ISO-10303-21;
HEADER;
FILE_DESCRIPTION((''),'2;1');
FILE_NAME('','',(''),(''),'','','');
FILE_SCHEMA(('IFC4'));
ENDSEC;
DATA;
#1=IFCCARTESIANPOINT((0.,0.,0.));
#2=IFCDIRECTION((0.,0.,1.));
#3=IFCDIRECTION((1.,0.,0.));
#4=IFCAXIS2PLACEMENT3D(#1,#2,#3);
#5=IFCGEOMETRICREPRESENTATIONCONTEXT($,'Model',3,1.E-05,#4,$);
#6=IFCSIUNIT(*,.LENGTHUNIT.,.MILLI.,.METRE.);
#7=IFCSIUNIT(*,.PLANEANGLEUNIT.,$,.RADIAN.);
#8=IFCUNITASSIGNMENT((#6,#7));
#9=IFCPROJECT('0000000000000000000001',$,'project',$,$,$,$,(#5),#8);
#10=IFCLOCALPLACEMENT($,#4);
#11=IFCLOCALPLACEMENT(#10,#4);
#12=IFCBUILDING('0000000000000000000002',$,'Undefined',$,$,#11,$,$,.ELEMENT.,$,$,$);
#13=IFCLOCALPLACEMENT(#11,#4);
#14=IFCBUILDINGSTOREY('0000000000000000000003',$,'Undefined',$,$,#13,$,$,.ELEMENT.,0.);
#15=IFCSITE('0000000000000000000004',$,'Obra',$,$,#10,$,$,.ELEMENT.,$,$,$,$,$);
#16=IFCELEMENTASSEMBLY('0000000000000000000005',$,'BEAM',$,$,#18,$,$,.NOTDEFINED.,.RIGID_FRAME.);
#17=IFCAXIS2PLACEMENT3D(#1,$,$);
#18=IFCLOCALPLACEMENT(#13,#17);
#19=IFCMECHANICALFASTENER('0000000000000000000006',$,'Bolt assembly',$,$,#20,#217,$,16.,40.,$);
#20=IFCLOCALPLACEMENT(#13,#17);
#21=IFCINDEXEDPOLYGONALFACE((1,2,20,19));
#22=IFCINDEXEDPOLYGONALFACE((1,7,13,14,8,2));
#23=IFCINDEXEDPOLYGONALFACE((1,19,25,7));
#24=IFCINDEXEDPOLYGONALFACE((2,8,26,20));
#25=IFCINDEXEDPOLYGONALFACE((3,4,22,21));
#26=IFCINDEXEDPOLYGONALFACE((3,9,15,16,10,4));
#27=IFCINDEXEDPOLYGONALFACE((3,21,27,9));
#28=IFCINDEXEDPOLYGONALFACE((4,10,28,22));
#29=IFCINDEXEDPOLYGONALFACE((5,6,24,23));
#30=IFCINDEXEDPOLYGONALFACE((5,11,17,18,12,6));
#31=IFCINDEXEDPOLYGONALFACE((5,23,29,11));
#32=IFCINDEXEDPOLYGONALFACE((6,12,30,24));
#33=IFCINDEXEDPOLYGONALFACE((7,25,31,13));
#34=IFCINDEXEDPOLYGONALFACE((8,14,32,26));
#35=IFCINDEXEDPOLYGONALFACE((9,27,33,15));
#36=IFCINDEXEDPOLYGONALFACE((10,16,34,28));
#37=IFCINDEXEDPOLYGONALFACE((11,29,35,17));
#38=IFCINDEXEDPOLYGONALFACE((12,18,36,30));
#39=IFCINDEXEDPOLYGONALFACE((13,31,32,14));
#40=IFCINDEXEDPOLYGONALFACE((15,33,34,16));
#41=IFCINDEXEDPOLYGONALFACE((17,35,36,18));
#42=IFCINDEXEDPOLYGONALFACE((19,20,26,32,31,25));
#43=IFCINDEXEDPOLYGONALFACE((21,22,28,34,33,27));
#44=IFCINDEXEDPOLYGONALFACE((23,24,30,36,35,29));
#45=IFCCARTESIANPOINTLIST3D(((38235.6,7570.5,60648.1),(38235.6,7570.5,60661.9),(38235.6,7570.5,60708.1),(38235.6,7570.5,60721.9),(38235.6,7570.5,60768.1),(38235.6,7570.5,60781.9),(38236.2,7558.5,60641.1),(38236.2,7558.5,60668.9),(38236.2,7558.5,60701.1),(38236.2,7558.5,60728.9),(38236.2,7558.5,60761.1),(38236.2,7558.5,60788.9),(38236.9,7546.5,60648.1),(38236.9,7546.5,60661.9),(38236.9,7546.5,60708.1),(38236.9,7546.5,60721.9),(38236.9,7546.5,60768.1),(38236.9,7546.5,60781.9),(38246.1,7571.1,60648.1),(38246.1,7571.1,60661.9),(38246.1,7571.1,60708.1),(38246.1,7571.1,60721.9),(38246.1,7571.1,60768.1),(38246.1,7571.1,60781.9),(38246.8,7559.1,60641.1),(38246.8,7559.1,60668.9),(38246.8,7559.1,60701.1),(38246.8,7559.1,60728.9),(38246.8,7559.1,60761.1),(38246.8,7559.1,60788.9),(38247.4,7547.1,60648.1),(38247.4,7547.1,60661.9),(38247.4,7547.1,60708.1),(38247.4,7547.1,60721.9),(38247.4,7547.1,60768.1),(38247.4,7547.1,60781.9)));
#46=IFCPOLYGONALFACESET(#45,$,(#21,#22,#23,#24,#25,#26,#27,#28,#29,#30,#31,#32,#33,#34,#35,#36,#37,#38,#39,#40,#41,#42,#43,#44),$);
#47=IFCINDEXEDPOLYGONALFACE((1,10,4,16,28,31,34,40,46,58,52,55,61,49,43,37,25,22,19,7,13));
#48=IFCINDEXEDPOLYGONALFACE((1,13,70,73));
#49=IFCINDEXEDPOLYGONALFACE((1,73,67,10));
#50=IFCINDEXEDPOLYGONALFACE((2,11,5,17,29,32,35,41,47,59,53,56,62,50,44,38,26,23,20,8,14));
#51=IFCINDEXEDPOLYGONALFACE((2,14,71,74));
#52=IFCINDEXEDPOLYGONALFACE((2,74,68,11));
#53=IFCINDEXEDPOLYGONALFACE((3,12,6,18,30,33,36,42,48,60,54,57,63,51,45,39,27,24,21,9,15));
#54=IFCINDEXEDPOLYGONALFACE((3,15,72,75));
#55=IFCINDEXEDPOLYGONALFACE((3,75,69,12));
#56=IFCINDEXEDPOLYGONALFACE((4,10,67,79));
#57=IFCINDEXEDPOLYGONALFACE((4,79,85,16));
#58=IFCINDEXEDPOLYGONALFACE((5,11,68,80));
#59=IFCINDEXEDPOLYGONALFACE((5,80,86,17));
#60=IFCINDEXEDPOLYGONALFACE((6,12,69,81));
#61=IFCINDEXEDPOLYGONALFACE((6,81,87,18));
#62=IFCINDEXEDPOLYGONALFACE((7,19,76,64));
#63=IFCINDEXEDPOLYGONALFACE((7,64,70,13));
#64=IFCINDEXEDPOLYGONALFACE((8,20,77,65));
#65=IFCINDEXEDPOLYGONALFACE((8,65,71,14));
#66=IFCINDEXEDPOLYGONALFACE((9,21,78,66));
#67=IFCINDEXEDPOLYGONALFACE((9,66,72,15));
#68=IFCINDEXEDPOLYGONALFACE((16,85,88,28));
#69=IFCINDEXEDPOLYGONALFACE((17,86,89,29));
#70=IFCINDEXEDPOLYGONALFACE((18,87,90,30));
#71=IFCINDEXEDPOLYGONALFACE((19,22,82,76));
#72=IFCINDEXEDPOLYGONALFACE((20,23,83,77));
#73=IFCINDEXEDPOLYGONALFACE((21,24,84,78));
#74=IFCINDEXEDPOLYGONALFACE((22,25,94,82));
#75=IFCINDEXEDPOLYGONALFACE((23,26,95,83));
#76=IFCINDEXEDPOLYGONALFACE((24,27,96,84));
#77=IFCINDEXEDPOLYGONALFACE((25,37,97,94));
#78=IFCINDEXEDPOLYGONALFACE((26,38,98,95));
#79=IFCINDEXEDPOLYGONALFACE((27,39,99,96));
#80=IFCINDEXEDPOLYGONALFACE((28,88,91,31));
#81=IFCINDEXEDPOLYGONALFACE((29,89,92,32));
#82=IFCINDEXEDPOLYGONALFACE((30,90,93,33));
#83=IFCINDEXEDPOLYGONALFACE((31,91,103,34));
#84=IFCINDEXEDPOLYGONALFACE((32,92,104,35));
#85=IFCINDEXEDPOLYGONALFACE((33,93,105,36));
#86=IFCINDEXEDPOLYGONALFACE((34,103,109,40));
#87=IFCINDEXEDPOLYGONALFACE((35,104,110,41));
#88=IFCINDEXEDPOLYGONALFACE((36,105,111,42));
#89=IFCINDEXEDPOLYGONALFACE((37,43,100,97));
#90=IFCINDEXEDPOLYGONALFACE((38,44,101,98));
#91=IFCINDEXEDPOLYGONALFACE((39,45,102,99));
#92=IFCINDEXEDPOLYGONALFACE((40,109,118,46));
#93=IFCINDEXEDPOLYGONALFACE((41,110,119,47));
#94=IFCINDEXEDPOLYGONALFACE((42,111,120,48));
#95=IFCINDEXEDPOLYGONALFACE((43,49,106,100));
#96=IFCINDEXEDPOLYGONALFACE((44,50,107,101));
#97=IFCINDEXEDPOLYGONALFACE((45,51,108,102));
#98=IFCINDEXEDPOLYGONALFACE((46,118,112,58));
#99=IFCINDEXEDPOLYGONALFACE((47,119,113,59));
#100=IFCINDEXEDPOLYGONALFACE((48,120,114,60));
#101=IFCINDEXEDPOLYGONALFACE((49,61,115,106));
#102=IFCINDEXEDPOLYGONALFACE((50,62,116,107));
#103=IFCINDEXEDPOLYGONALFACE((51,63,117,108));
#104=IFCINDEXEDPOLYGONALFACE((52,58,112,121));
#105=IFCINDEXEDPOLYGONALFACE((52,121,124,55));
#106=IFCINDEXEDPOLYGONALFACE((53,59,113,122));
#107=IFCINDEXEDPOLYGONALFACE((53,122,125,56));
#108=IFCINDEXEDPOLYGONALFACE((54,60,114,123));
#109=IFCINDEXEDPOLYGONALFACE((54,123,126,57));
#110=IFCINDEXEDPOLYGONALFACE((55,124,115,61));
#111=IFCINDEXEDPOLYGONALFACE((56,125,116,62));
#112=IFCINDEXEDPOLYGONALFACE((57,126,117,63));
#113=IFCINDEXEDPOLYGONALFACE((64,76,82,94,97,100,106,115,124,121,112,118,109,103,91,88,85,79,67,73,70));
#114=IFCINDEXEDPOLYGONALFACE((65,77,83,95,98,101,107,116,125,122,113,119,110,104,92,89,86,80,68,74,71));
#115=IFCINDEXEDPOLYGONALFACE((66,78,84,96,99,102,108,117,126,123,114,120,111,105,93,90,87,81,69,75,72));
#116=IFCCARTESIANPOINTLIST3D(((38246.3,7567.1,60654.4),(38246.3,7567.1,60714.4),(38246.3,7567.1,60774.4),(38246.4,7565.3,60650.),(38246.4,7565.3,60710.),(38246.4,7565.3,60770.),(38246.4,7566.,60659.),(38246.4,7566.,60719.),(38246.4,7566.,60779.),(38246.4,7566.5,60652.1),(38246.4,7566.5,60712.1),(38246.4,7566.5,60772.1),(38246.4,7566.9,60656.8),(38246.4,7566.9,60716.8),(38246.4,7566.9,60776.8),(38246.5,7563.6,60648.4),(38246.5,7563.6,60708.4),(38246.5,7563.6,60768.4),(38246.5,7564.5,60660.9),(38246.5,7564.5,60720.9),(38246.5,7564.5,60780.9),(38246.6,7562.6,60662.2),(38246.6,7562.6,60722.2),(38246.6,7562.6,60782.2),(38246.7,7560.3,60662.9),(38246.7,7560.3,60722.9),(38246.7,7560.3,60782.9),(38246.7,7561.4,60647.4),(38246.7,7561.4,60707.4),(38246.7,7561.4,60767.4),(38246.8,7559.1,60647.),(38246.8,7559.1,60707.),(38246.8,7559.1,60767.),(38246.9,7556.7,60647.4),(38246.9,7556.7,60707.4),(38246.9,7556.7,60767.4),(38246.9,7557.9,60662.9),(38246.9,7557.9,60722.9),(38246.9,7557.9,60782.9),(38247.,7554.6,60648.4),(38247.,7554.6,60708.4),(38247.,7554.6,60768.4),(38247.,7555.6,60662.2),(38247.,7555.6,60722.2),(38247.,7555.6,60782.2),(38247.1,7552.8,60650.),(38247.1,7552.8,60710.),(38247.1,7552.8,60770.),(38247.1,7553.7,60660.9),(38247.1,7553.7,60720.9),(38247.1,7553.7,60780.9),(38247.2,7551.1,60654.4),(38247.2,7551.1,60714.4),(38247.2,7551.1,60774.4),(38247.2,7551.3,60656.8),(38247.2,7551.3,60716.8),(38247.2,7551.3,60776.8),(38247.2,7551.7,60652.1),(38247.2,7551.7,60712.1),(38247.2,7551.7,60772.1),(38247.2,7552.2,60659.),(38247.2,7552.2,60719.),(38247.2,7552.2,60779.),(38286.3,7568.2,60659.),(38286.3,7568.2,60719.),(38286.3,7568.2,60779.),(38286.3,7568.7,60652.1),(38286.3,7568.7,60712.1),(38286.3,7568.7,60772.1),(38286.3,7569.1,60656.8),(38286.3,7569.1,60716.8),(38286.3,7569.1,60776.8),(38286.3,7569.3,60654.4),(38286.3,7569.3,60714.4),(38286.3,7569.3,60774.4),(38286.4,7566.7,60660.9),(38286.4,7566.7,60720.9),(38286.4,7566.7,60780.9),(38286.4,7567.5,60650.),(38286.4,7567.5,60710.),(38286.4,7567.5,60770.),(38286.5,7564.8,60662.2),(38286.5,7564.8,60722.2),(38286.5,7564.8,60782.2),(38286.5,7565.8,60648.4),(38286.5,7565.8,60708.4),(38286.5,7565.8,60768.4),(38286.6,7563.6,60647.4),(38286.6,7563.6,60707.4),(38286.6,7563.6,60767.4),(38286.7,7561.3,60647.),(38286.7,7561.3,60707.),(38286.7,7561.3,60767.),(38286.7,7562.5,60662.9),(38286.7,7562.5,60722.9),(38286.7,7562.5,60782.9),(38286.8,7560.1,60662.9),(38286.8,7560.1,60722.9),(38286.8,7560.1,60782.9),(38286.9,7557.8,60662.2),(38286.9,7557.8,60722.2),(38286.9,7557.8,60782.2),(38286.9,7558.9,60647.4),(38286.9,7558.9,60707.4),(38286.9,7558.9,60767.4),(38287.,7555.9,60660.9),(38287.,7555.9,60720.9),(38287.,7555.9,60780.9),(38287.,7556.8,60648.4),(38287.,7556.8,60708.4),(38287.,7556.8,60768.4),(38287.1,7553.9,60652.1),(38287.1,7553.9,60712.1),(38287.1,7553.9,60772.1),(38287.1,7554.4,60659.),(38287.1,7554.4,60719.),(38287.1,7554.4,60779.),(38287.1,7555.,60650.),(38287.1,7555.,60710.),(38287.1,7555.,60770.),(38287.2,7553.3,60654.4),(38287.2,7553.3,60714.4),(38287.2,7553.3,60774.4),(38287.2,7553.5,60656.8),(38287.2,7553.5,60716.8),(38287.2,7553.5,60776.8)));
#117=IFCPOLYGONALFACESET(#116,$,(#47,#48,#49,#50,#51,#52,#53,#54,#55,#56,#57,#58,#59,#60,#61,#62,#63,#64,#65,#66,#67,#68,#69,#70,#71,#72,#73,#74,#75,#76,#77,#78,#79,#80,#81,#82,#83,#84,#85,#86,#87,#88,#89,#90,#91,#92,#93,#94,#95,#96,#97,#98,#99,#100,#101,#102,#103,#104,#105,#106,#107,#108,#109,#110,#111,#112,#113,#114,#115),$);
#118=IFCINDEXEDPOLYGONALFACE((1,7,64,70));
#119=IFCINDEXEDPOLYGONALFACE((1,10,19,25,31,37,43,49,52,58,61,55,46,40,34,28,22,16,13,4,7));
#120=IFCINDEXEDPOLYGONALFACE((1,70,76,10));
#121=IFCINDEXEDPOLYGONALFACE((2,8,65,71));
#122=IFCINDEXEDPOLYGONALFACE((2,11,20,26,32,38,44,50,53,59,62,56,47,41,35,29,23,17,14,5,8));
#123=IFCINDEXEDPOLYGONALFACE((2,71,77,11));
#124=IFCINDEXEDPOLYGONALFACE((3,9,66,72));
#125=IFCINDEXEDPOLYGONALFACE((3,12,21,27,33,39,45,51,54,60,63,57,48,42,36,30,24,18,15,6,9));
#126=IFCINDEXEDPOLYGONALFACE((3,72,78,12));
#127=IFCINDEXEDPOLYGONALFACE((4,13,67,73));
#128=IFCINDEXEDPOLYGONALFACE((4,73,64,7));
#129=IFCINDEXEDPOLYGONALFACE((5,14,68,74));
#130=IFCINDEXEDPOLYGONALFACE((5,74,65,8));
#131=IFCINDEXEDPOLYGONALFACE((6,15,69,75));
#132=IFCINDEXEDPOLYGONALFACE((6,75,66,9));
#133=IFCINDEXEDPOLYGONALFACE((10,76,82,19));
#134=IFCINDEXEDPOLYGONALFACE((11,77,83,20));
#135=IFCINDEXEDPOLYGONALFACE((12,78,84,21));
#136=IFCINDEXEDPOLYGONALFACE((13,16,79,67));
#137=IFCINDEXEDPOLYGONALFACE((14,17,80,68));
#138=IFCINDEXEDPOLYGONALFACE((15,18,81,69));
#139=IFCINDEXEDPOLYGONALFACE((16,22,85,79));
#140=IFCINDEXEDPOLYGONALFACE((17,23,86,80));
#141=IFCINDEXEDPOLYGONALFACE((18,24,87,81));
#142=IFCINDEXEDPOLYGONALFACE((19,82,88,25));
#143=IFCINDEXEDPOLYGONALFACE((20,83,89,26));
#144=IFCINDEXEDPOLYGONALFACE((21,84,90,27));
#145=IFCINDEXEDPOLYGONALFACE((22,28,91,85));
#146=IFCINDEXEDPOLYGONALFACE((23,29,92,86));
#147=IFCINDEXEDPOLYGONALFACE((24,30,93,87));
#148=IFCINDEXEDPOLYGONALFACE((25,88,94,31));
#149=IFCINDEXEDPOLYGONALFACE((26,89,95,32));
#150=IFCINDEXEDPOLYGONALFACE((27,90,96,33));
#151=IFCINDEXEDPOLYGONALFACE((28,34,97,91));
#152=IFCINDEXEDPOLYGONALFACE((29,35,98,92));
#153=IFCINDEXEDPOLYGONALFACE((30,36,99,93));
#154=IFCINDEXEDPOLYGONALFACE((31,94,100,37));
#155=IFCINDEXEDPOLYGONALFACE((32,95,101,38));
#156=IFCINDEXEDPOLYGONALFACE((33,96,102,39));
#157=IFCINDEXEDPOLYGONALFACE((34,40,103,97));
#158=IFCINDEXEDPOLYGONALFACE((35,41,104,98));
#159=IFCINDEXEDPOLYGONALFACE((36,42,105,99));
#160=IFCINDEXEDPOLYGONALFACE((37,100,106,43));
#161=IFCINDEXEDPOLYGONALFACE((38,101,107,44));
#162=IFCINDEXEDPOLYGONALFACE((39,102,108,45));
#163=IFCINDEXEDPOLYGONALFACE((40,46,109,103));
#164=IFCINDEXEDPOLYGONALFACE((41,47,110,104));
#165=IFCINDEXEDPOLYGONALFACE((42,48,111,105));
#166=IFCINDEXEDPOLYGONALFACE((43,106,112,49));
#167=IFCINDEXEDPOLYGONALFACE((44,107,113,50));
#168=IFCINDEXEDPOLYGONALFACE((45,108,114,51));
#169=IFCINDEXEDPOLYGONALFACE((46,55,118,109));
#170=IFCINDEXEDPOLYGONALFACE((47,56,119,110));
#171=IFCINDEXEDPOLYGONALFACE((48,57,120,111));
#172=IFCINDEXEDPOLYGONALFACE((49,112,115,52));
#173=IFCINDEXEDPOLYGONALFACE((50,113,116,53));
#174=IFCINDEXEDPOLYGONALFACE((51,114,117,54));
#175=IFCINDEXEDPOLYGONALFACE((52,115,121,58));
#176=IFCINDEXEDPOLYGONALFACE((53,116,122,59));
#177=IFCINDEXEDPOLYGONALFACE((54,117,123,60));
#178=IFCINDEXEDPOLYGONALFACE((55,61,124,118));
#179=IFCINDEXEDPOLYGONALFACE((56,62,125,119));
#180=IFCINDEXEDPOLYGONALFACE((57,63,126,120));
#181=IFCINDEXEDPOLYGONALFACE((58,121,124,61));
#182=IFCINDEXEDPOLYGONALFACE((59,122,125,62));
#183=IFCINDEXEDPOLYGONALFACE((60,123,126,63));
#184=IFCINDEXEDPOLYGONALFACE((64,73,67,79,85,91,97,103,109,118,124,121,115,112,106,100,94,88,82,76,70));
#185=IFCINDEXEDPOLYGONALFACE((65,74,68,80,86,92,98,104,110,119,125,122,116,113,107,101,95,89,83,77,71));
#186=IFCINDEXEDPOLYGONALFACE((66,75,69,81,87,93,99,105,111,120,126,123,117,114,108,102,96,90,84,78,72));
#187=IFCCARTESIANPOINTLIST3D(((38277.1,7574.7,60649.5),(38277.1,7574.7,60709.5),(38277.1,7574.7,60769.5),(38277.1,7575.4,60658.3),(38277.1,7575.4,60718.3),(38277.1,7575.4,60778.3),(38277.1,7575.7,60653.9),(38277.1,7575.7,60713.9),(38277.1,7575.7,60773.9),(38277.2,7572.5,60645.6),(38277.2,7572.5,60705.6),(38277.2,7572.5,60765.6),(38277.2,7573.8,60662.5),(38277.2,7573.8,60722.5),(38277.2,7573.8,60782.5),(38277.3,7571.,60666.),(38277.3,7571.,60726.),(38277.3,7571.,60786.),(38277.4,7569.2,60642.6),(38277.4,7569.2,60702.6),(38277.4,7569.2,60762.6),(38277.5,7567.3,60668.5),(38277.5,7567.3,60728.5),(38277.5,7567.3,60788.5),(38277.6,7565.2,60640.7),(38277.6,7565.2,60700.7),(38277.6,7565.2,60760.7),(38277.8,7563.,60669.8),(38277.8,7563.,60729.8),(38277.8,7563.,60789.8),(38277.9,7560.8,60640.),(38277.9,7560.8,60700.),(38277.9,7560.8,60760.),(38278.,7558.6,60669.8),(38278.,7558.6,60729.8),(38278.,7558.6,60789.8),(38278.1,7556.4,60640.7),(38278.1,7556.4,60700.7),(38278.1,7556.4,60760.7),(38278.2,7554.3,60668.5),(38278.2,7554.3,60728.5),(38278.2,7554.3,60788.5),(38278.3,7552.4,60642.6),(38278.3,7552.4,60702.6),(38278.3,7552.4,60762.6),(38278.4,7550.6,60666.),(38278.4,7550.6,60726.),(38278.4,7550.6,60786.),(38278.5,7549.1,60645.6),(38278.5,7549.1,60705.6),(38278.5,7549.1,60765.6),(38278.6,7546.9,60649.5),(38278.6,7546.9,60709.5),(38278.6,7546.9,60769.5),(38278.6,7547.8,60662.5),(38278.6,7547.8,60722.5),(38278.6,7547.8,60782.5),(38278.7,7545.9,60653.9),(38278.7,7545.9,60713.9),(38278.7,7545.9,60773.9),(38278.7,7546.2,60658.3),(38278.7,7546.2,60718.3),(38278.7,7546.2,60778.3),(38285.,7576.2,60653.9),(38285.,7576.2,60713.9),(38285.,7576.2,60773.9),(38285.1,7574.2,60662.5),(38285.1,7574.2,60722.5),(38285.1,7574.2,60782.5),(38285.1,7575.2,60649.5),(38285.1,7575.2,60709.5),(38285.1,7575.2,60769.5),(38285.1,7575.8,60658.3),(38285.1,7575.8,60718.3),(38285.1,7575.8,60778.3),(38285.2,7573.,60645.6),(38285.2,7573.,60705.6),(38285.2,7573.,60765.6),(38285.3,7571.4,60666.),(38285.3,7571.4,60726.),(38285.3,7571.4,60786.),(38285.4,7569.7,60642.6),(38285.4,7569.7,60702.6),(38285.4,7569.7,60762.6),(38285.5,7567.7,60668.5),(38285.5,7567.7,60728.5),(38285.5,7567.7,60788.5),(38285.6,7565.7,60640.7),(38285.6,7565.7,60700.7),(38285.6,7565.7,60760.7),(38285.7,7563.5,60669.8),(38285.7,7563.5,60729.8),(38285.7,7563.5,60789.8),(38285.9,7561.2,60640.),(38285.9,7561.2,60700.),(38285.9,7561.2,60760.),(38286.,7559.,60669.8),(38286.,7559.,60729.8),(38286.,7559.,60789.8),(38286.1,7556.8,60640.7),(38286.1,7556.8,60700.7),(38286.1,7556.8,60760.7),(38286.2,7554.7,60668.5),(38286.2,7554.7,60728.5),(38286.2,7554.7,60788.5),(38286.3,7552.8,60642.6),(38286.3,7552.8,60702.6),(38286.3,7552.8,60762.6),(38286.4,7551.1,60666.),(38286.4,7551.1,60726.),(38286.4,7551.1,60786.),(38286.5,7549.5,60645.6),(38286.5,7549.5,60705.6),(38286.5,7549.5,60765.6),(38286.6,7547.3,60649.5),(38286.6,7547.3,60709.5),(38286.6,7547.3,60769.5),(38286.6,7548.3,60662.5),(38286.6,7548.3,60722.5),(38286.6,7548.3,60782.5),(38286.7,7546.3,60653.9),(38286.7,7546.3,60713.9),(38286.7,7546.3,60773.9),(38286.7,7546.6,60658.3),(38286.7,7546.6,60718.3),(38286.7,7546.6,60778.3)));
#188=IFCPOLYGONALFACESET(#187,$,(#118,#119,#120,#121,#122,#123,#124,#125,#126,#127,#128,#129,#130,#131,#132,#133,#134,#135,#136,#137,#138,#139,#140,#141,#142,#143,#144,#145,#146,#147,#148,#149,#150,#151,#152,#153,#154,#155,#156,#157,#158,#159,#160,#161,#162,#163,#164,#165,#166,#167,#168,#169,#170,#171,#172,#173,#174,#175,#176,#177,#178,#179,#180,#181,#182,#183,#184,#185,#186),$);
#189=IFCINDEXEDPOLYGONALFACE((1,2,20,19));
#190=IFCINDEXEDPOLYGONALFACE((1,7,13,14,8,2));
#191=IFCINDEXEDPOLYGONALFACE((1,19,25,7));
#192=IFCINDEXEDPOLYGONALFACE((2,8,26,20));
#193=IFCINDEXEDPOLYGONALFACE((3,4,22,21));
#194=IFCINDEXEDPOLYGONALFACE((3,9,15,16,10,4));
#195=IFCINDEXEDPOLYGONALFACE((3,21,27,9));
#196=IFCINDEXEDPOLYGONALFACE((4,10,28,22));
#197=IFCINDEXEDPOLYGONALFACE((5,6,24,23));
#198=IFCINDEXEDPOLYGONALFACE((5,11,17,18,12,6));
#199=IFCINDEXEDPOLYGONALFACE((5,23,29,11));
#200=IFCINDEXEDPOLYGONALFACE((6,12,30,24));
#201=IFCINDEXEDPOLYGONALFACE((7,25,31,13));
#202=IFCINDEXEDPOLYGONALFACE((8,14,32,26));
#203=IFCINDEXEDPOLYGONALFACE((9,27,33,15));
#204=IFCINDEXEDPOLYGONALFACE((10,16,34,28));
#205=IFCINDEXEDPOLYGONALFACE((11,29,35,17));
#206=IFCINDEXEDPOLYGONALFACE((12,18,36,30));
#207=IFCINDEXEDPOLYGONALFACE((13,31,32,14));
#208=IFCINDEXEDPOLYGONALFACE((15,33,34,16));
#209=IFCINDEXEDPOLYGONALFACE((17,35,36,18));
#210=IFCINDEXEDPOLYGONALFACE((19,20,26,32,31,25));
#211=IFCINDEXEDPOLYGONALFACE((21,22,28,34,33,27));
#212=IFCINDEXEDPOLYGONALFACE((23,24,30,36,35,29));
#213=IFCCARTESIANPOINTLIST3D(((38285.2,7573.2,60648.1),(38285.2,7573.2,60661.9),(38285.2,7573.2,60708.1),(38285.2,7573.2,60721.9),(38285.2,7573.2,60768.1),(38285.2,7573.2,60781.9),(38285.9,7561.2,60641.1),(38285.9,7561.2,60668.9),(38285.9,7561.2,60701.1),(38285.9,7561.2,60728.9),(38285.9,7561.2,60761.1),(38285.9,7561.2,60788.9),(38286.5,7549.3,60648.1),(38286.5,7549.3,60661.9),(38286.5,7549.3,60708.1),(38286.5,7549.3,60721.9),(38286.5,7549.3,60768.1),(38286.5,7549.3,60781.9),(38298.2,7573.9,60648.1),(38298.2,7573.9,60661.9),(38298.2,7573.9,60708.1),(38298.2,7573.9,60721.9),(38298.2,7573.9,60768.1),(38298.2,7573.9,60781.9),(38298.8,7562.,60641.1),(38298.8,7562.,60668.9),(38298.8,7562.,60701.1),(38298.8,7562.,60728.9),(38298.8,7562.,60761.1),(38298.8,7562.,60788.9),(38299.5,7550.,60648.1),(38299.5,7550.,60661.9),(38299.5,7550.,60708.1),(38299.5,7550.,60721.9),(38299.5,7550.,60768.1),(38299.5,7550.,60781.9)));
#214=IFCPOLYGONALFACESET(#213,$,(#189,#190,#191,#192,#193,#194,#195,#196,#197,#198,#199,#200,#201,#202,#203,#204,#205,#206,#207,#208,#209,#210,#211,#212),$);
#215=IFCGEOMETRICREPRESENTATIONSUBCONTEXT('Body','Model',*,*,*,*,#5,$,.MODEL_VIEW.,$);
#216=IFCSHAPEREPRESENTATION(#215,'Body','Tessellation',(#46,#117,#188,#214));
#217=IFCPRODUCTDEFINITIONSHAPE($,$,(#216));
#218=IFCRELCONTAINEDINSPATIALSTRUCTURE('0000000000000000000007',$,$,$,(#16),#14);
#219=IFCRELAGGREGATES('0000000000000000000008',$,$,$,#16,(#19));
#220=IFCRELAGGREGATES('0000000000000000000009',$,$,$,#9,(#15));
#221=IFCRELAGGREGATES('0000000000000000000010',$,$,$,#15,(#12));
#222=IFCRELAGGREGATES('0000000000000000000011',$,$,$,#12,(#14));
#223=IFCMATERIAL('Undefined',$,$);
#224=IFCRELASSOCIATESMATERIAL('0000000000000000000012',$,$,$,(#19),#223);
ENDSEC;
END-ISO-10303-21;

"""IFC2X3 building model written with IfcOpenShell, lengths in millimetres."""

from ifc_helpers import new_model, si_unit, frame, origin_with_axes, origin_2d_with_axis, place, context, subcontext, project, spatial, polyline, circle, outline, extrude, source, transform, mapped, material, element, aggregate, save


model = new_model("IFC2X3")

# Units and contexts
model_context = context("Model", 3, precision=1e-05, world=origin_with_axes())
body_context = subcontext(model_context, "Body", "Model", "MODEL_VIEW")
ifc_project = project(units=[si_unit("LENGTHUNIT", "METRE", prefix="MILLI"), si_unit("PLANEANGLEUNIT", "RADIAN")], contexts=[model_context])

# Site, building, storey
site_placement = place(None, origin_with_axes())
site = spatial("IfcSite", under=ifc_project, at=site_placement, Name="Obra", CompositionType="ELEMENT")
building_placement = place(site_placement, origin_with_axes())
building = spatial("IfcBuilding", under=site, at=building_placement, Name="Undefined", CompositionType="ELEMENT")
storey_placement = place(building_placement, origin_with_axes())
storey = spatial("IfcBuildingStorey", under=building, at=storey_placement, Name="Undefined", CompositionType="ELEMENT", Elevation=0.0)

# Element assembly, mechanical fastener
ifc_material_1 = material(Name="Undefined")
shared_shape_1 = source(origin_with_axes(), body_context, "Body", "SweptSolid", [
    extrude(outline(polyline([(13.9, 0.0), (6.9, 12.0), (-6.9, 12.0), (-13.9, 0.0), (-6.9, -12.0), (6.9, -12.0), (13.9, 0.0)])), frame((0.0, -44.8, 0.0), z_axis=(0.0, 1.0, 0.0), x_axis=(1.0, 0.0, 0.0)), (0.0, 0.0, 1.0), 10.6),
    extrude(circle(Radius=8.0, at=origin_2d_with_axis()), frame((0.0, -34.2, 0.0), z_axis=(0.0, 1.0, 0.0), x_axis=(1.0, 0.0, 0.0)), (0.0, 0.0, 1.0), 40.0),
    extrude(circle(Radius=15.0, at=origin_2d_with_axis()), frame((0.0, -3.1, 0.0), z_axis=(0.0, 1.0, 0.0), x_axis=(1.0, 0.0, 0.0)), (0.0, 0.0, 1.0), 8.0),
    extrude(outline(polyline([(13.9, 0.0), (6.9, 12.0), (-6.9, 12.0), (-13.9, 0.0), (-6.9, -12.0), (6.9, -12.0), (13.9, 0.0)])), frame((0.0, 4.9, 0.0), z_axis=(0.0, 1.0, 0.0), x_axis=(1.0, 0.0, 0.0)), (0.0, 0.0, 1.0), 13.0),
])
assembly_1_placement = place(storey_placement, origin_with_axes())
assembly_1 = element("IfcElementAssembly", 1, at=assembly_1_placement, inside=storey, Name="BEAM", AssemblyPlace="NOTDEFINED", PredefinedType="RIGID_FRAME")
mechanical_fastener_1_placement = place(assembly_1_placement, frame((38278.2, 7610.9, 60835.0), z_axis=(0.055152, -0.998478, 0.0), x_axis=(0.0, 0.0, -1.0)))
mechanical_fastener_1 = element("IfcMechanicalFastener", 2, at=mechanical_fastener_1_placement, material=ifc_material_1, Name="Bolt assembly", NominalDiameter=16.0, NominalLength=40.0, context=body_context, shape_type="MappedRepresentation", body=[
    mapped(shared_shape_1, transform((60.0, 0.0, 50.0))),
    mapped(shared_shape_1, transform((120.0, 0.0, 50.0))),
    mapped(shared_shape_1, transform((180.0, 0.0, 50.0))),
])

aggregate(assembly_1, [mechanical_fastener_1])

save(model, "model.ifc")
